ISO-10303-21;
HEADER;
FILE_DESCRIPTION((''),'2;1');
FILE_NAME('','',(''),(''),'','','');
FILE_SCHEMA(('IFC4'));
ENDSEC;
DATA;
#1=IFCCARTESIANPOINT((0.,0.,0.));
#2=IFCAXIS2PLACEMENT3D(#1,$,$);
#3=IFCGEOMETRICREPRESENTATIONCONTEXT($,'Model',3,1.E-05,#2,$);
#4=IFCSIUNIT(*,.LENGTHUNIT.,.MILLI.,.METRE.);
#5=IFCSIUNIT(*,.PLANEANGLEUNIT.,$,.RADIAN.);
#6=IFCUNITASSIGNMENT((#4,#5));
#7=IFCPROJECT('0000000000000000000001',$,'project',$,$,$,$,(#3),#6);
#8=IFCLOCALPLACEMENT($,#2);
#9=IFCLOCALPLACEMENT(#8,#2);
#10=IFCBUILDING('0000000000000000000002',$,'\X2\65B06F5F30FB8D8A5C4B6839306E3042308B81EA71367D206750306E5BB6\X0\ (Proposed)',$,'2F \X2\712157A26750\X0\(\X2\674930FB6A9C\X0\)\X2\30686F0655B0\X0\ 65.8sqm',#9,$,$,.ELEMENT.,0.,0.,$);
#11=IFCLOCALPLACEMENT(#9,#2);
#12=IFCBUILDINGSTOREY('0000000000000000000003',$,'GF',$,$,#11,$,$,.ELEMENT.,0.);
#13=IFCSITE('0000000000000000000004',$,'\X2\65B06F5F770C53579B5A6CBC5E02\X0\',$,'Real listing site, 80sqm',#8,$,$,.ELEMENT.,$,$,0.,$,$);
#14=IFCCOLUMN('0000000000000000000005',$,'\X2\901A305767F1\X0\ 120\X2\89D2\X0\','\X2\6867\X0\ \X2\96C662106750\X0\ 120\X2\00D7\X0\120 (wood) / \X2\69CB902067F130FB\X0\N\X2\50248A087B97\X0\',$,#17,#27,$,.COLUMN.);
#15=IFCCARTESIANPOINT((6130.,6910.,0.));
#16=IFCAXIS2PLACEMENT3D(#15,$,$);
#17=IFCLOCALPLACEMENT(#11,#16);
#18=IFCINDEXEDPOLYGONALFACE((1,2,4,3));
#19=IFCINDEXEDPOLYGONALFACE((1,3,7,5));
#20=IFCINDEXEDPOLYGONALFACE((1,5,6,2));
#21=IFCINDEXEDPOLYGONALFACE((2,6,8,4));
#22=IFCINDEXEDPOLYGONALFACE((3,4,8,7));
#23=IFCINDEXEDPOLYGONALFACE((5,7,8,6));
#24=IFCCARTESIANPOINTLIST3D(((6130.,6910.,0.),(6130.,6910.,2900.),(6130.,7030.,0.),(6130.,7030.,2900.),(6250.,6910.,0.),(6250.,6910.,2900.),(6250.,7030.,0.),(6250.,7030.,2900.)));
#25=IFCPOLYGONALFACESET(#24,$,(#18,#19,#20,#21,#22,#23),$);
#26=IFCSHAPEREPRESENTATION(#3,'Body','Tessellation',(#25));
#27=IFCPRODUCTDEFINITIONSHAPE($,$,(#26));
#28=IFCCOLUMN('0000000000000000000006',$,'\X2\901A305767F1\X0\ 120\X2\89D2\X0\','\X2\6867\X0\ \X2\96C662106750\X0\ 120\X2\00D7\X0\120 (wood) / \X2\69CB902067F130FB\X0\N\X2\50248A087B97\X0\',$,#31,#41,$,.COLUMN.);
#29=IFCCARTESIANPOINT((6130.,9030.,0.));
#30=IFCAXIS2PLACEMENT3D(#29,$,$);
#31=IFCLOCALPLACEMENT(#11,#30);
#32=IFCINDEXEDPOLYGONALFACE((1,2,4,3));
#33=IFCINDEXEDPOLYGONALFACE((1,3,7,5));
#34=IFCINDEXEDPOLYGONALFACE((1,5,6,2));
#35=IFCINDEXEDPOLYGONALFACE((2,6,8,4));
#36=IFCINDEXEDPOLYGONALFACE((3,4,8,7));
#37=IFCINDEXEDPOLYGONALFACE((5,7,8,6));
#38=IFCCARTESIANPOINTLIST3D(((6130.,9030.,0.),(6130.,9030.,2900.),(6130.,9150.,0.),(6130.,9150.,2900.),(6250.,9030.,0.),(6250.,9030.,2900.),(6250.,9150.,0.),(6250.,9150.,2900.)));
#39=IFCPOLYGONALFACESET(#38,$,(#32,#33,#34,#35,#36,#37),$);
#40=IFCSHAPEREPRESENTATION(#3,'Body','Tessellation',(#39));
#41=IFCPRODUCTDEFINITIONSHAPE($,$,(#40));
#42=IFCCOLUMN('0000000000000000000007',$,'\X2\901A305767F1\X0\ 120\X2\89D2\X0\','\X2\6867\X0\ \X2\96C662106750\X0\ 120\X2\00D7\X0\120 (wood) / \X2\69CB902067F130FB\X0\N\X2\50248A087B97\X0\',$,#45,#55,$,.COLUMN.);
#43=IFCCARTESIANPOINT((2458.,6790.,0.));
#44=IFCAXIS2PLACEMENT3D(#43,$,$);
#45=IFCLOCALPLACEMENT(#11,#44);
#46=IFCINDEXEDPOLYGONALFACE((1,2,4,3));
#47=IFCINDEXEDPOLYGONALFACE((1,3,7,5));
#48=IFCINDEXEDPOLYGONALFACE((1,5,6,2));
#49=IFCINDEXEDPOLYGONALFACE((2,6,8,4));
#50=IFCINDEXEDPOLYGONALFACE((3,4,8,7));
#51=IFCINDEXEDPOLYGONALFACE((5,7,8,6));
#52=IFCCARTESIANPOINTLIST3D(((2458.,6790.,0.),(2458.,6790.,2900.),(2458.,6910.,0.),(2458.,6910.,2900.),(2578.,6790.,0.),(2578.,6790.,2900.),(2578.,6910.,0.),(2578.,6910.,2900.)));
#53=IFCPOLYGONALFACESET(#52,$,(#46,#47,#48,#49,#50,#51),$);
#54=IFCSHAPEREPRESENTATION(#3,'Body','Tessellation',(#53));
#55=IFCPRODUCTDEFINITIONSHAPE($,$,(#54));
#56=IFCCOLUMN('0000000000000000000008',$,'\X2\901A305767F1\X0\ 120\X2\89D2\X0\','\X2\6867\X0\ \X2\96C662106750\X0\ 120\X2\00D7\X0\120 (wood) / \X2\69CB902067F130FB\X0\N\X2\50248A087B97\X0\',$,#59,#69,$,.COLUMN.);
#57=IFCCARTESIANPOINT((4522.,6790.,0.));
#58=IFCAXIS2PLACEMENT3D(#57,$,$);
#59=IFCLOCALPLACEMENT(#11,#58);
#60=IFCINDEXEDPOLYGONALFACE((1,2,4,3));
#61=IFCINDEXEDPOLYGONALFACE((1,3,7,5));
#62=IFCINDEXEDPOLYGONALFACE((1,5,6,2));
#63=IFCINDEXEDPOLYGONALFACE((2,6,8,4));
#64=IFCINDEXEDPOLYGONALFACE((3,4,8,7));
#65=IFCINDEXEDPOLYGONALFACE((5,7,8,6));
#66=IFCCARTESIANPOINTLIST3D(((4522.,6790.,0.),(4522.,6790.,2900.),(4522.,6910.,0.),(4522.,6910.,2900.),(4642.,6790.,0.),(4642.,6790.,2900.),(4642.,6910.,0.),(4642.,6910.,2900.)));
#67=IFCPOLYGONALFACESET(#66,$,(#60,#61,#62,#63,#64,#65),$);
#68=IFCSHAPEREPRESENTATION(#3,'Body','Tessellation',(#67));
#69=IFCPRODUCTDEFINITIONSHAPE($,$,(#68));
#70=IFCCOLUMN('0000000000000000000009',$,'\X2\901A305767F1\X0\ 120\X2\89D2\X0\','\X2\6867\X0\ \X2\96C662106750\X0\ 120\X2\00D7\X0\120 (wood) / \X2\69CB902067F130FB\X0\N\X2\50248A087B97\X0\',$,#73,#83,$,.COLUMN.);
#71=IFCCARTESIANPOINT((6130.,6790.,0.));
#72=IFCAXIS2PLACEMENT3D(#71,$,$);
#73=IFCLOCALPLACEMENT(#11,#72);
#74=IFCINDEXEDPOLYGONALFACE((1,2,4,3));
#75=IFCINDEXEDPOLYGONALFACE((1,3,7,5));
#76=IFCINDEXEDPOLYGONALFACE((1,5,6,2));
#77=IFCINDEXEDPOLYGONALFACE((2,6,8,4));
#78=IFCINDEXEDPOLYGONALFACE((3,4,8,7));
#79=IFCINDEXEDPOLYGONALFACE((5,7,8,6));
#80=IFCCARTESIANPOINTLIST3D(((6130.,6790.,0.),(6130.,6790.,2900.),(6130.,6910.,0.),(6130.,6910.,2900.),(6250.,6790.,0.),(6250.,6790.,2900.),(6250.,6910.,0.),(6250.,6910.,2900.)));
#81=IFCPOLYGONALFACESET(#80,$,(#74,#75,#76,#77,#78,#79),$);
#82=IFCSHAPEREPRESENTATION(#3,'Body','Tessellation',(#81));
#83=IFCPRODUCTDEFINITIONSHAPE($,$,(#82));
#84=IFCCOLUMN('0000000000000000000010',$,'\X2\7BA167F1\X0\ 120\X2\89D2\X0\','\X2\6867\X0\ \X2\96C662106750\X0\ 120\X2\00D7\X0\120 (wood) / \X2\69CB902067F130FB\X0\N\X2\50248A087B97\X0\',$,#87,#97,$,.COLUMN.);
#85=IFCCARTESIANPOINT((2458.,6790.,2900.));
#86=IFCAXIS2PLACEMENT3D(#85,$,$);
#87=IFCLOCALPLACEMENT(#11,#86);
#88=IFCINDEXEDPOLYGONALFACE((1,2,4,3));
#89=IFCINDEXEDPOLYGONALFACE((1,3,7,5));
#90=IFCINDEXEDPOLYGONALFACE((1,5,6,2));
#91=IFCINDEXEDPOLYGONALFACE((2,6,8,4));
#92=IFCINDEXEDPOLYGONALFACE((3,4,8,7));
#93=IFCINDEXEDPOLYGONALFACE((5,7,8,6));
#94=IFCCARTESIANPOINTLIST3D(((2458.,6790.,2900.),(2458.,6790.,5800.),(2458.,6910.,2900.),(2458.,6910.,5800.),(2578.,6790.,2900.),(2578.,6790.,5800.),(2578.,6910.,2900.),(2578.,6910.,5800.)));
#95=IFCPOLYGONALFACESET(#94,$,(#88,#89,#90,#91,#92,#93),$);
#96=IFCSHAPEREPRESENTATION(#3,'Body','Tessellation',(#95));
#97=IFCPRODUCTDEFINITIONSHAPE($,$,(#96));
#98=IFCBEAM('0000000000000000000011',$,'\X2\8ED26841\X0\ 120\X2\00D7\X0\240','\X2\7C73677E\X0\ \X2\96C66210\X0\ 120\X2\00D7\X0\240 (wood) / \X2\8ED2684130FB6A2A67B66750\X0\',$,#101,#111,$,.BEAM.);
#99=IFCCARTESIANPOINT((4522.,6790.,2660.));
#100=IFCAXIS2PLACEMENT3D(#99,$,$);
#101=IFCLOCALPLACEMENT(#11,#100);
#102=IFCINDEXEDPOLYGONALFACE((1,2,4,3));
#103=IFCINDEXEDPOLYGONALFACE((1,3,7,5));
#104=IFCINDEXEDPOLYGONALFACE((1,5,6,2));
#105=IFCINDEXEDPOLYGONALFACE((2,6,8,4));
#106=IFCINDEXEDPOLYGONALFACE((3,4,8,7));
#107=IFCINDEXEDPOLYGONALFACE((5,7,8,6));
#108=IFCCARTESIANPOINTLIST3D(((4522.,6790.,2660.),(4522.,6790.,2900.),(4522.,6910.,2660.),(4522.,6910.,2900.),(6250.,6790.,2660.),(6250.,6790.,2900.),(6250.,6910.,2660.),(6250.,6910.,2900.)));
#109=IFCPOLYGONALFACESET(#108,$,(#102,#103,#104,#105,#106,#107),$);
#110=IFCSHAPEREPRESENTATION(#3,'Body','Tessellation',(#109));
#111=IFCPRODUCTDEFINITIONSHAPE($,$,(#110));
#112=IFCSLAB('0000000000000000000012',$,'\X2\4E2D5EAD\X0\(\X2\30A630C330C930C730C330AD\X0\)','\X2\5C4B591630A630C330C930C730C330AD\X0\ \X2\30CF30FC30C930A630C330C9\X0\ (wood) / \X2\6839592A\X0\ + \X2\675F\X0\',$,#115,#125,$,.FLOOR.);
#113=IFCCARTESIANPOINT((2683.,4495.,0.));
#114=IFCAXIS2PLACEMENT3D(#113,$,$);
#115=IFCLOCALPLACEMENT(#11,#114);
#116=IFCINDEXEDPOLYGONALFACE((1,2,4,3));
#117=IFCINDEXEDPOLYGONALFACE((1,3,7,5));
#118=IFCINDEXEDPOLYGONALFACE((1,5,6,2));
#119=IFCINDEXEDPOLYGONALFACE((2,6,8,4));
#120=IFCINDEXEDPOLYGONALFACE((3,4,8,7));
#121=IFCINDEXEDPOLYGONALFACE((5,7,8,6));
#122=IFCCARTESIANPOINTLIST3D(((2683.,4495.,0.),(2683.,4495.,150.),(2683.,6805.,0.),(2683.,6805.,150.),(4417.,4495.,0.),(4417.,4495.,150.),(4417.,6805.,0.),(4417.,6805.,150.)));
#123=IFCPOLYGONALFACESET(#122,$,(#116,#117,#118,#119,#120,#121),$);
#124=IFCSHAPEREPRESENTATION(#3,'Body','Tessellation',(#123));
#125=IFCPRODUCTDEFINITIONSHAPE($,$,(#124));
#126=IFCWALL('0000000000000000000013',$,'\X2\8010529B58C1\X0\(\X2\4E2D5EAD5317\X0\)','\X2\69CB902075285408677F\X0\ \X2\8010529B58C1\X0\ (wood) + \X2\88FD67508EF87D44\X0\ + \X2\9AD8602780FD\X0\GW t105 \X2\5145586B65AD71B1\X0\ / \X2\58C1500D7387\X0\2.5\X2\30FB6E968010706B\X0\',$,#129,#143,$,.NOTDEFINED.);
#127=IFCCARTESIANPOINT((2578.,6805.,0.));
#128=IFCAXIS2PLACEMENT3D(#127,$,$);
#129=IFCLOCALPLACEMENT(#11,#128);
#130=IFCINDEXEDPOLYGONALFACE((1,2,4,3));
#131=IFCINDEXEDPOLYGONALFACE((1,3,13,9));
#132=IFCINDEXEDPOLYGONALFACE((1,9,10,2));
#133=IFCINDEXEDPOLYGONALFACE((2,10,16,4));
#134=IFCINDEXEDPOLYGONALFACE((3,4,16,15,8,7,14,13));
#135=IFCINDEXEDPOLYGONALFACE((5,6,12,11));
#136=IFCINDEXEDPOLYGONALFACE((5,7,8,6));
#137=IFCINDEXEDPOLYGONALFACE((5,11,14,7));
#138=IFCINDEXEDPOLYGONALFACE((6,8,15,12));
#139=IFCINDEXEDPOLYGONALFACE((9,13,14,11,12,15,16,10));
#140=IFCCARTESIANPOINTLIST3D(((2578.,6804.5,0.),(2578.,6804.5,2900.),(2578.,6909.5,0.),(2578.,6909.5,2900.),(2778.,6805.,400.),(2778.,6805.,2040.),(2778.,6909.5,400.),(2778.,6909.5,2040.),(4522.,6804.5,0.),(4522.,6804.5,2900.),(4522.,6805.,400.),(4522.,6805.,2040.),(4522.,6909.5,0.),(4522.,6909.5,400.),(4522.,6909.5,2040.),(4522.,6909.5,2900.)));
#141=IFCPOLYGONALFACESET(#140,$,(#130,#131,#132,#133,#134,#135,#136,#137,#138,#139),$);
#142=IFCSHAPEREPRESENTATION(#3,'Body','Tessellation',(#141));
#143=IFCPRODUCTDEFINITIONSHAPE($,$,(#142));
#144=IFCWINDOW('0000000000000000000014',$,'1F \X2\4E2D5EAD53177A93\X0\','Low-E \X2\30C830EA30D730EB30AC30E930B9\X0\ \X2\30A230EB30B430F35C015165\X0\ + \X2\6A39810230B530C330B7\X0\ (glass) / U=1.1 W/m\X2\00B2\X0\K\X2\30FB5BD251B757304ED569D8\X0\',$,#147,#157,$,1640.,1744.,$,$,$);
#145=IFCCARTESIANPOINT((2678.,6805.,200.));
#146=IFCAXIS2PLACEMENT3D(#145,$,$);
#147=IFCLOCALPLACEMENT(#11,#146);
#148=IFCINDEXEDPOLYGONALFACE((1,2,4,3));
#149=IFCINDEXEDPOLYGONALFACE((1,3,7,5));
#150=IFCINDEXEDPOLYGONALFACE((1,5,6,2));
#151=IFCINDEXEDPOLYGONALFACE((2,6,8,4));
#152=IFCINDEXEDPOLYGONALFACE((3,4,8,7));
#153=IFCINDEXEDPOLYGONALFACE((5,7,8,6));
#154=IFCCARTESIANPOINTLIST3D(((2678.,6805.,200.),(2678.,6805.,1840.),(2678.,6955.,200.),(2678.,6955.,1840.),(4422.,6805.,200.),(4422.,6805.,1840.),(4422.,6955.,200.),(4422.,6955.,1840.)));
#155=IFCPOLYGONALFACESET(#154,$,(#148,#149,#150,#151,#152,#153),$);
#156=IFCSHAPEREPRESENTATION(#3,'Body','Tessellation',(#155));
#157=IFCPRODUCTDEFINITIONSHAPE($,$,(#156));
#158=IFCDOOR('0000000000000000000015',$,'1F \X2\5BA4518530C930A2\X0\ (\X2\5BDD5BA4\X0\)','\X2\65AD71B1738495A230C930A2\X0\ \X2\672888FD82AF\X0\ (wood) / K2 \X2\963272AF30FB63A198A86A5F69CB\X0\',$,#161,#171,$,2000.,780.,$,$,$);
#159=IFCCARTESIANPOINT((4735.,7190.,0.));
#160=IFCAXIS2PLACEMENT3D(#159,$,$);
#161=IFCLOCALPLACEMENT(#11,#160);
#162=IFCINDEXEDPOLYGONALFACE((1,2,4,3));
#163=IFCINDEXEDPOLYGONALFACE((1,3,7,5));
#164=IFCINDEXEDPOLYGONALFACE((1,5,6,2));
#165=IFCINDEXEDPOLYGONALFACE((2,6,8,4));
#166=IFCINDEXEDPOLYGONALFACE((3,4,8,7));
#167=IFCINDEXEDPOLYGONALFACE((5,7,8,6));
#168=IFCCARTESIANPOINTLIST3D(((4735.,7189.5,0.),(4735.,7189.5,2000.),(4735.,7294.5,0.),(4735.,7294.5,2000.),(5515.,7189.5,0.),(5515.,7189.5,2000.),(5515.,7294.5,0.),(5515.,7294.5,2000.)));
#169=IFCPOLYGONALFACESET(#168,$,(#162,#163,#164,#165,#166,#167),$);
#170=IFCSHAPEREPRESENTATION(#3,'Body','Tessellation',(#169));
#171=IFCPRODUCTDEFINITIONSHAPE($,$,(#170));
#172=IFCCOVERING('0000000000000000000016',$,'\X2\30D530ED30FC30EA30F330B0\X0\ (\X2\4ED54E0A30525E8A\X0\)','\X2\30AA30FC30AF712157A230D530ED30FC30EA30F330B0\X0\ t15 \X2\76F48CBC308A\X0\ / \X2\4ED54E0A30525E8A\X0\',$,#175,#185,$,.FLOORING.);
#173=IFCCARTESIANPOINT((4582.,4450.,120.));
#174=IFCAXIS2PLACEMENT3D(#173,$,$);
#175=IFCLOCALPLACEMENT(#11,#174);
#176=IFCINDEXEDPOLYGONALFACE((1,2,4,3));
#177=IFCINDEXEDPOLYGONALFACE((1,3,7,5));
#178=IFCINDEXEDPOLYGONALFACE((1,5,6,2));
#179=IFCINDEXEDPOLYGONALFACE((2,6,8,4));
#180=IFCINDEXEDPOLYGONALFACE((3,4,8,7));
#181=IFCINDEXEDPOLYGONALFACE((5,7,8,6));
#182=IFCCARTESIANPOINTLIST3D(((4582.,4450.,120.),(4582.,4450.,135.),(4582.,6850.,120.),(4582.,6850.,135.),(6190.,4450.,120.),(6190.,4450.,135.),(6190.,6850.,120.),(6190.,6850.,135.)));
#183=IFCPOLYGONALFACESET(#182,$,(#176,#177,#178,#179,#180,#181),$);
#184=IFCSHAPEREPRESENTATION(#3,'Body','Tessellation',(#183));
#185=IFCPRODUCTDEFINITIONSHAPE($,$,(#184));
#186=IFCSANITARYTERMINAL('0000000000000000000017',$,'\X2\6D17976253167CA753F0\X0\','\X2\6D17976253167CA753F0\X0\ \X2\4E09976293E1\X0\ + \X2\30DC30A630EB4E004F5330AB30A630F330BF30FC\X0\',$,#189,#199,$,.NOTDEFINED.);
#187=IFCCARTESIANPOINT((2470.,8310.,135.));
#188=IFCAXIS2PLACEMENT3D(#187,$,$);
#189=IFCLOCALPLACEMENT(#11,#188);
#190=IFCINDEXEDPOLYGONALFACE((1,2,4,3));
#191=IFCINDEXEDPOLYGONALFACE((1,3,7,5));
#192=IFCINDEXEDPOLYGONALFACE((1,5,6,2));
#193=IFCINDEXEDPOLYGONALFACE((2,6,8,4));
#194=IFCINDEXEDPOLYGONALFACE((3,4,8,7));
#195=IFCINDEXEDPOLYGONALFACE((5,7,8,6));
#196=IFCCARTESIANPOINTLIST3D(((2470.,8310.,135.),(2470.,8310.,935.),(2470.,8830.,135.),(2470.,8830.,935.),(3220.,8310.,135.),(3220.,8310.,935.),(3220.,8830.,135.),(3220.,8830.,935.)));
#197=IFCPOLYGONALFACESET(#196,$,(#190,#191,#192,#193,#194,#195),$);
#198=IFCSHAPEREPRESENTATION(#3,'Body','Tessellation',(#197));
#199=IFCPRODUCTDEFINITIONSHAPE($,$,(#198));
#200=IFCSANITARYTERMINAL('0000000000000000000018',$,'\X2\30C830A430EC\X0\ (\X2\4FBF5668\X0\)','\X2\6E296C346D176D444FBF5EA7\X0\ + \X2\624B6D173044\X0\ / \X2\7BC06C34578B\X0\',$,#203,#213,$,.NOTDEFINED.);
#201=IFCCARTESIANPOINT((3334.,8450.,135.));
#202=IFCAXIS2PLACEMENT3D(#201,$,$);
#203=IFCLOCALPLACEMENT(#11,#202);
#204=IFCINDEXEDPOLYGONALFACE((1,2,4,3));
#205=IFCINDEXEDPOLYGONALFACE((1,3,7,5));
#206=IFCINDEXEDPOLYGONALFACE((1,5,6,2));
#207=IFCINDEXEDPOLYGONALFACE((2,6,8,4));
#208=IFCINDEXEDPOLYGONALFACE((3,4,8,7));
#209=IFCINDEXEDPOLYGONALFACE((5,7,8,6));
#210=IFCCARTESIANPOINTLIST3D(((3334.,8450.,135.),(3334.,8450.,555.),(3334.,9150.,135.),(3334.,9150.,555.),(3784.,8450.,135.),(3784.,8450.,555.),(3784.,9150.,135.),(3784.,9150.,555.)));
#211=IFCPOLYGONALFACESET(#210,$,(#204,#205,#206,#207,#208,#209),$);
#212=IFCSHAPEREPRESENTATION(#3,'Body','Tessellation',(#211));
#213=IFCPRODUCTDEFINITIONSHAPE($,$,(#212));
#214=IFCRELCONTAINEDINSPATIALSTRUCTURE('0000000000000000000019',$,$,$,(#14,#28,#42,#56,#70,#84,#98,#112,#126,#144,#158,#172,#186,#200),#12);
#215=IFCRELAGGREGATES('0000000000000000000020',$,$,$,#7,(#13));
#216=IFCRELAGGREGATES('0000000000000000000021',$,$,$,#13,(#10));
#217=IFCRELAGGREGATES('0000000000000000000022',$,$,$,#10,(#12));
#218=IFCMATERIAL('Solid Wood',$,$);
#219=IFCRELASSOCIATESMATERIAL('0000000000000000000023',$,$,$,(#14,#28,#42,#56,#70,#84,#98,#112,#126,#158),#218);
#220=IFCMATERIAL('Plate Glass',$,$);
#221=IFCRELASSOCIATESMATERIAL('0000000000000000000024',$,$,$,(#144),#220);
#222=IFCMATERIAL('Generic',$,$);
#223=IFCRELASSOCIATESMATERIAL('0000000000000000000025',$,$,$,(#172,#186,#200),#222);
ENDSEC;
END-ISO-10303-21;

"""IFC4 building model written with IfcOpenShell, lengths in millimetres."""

from ifc_helpers import new_model, si_unit, frame, frame_2d, origin, place, context, project, spatial, rectangle, extrude, material, element, fill, save


model = new_model("IFC4")

# Units and contexts
model_context = context("Model", 3, precision=1e-05, world=origin())
ifc_project = project(units=[si_unit("LENGTHUNIT", "METRE", prefix="MILLI"), si_unit("PLANEANGLEUNIT", "RADIAN")], contexts=[model_context])

# Site, building, storey
site_placement = place(None, origin())
site = spatial("IfcSite", under=ifc_project, at=site_placement, Name="新潟県南魚沼市", ObjectType="Real listing site, 80sqm", CompositionType="ELEMENT", RefElevation=0.0)
building_placement = place(site_placement, origin())
building = spatial("IfcBuilding", under=site, at=building_placement, Name="新潟・越屋根のある自然素材の家 (Proposed)", ObjectType="2F 無垢材(杉・檜)と漆喰 65.8sqm", CompositionType="ELEMENT", ElevationOfRefHeight=0.0, ElevationOfTerrain=0.0)
storey_placement = place(building_placement, origin())
storey = spatial("IfcBuildingStorey", under=building, at=storey_placement, Name="GF", CompositionType="ELEMENT", Elevation=0.0)

# Columns
ifc_material_1 = material(Name="Solid Wood")
column_1_placement = place(storey_placement, frame((6130.0, 6910.0, 0.0)))
element("IfcColumn", 1, at=column_1_placement, inside=storey, material=ifc_material_1, Name="通し柱 120角", Description="桧 集成材 120×120 (wood) / 構造柱・N値計算", PredefinedType="COLUMN", context=model_context, shape_type="SweptSolid", body=[
    extrude(rectangle(XDim=120.0, YDim=120.0, at=frame_2d((60.0, 60.0))), frame((6130.0, 6910.0, 0.0)), (0.0, 0.0, 1.0), 2900.0),
])
column_2_placement = place(storey_placement, frame((6130.0, 9030.0, 0.0)))
element("IfcColumn", 2, at=column_2_placement, inside=storey, material=ifc_material_1, Name="通し柱 120角", Description="桧 集成材 120×120 (wood) / 構造柱・N値計算", PredefinedType="COLUMN", context=model_context, shape_type="SweptSolid", body=[
    extrude(rectangle(XDim=120.0, YDim=120.0, at=frame_2d((60.0, 60.0))), frame((6130.0, 9030.0, 0.0)), (0.0, 0.0, 1.0), 2900.0),
])
column_3_placement = place(storey_placement, frame((2458.0, 6790.0, 0.0)))
element("IfcColumn", 3, at=column_3_placement, inside=storey, material=ifc_material_1, Name="通し柱 120角", Description="桧 集成材 120×120 (wood) / 構造柱・N値計算", PredefinedType="COLUMN", context=model_context, shape_type="SweptSolid", body=[
    extrude(rectangle(XDim=120.0, YDim=120.0, at=frame_2d((60.0, 60.0))), frame((2458.0, 6790.0, 0.0)), (0.0, 0.0, 1.0), 2900.0),
])
column_4_placement = place(storey_placement, frame((4522.0, 6790.0, 0.0)))
element("IfcColumn", 4, at=column_4_placement, inside=storey, material=ifc_material_1, Name="通し柱 120角", Description="桧 集成材 120×120 (wood) / 構造柱・N値計算", PredefinedType="COLUMN", context=model_context, shape_type="SweptSolid", body=[
    extrude(rectangle(XDim=120.0, YDim=120.0, at=frame_2d((60.0, 60.0))), frame((4522.0, 6790.0, 0.0)), (0.0, 0.0, 1.0), 2900.0),
])
column_5_placement = place(storey_placement, frame((6130.0, 6790.0, 0.0)))
element("IfcColumn", 5, at=column_5_placement, inside=storey, material=ifc_material_1, Name="通し柱 120角", Description="桧 集成材 120×120 (wood) / 構造柱・N値計算", PredefinedType="COLUMN", context=model_context, shape_type="SweptSolid", body=[
    extrude(rectangle(XDim=120.0, YDim=120.0, at=frame_2d((60.0, 60.0))), frame((6130.0, 6790.0, 0.0)), (0.0, 0.0, 1.0), 2900.0),
])
column_6_placement = place(storey_placement, frame((2458.0, 6790.0, 2900.0)))
element("IfcColumn", 6, at=column_6_placement, inside=storey, material=ifc_material_1, Name="管柱 120角", Description="桧 集成材 120×120 (wood) / 構造柱・N値計算", PredefinedType="COLUMN", context=model_context, shape_type="SweptSolid", body=[
    extrude(rectangle(XDim=120.0, YDim=120.0, at=frame_2d((60.0, 60.0))), frame((2458.0, 6790.0, 2900.0)), (0.0, 0.0, 1.0), 2900.0),
])

# Beam
beam_1_placement = place(storey_placement, frame((4522.0, 6790.0, 2660.0)))
element("IfcBeam", 7, at=beam_1_placement, inside=storey, material=ifc_material_1, Name="軒桁 120×240", Description="米松 集成 120×240 (wood) / 軒桁・横架材", PredefinedType="BEAM", context=model_context, shape_type="SweptSolid", body=[
    extrude(rectangle(XDim=1728.0, YDim=120.0, at=frame_2d((864.0, 60.0))), frame((4522.0, 6790.0, 2660.0)), (0.0, 0.0, 1.0), 240.0),
])

# Slab
slab_placement = place(storey_placement, frame((2683.0, 4495.0, 0.0)))
element("IfcSlab", 8, at=slab_placement, inside=storey, material=ifc_material_1, Name="中庭(ウッドデッキ)", Description="屋外ウッドデッキ ハードウッド (wood) / 根太 + 束", PredefinedType="FLOOR", context=model_context, shape_type="SweptSolid", body=[
    extrude(rectangle(XDim=1734.0, YDim=2310.0, at=frame_2d((867.0, 1155.0))), frame((2683.0, 4495.0, 0.0)), (0.0, 0.0, 1.0), 150.0),
])

# Wall, opening, window
wall_1_placement = place(storey_placement, frame((2578.0, 6805.0, 0.0)))
wall_1 = element("IfcWall", 9, at=wall_1_placement, inside=storey, material=ifc_material_1, Name="耐力壁(中庭北)", Description="構造用合板 耐力壁 (wood) + 製材軸組 + 高性能GW t105 充填断熱 / 壁倍率2.5・準耐火", PredefinedType="NOTDEFINED", context=model_context, shape_type="SweptSolid", body=[
    extrude(rectangle(XDim=1944.0, YDim=105.0, at=frame_2d((972.0, 52.0))), frame((2578.0, 6805.0, 0.0)), (0.0, 0.0, 1.0), 2900.0),
])
opening_placement = place(storey_placement, frame((2678.0, 6805.0, 200.0)))
opening = element("IfcOpeningElement", 10, at=opening_placement, cuts=wall_1, PredefinedType="NOTDEFINED", context=model_context, shape_type="SweptSolid", body=[
    extrude(rectangle(XDim=1744.0, YDim=150.0, at=frame_2d((872.0, 75.0))), frame((2678.0, 6805.0, 200.0)), (0.0, 0.0, 1.0), 1640.0),
])
ifc_material_2 = material(Name="Plate Glass")
window_placement = place(storey_placement, frame((2678.0, 6805.0, 200.0)))
window = element("IfcWindow", 11, at=window_placement, inside=storey, material=ifc_material_2, Name="1F 中庭北窓", Description="Low-E トリプルガラス アルゴン封入 + 樹脂サッシ (glass) / U=1.1 W/m²K・寒冷地仕様", OverallHeight=1640.0, OverallWidth=1744.0, context=model_context, shape_type="SweptSolid", body=[
    extrude(rectangle(XDim=1744.0, YDim=150.0, at=frame_2d((872.0, 75.0))), frame((2678.0, 6805.0, 200.0)), (0.0, 0.0, 1.0), 1640.0),
])
fill(opening, window)

# Door
door_placement = place(storey_placement, frame((4735.0, 7190.0, 0.0)))
element("IfcDoor", 12, at=door_placement, inside=storey, material=ifc_material_1, Name="1F 室内ドア (寝室)", Description="断熱玄関ドア 木製芯 (wood) / K2 防犯・採風機構", OverallHeight=2000.0, OverallWidth=780.0, context=model_context, shape_type="SweptSolid", body=[
    extrude(rectangle(XDim=780.0, YDim=105.0, at=frame_2d((390.0, 52.0))), frame((4735.0, 7190.0, 0.0)), (0.0, 0.0, 1.0), 2000.0),
])

# Covering
ifc_material_3 = material(Name="Generic")
covering_placement = place(storey_placement, frame((4582.0, 4450.0, 120.0)))
element("IfcCovering", 13, at=covering_placement, inside=storey, material=ifc_material_3, Name="フローリング (仕上げ床)", Description="オーク無垢フローリング t15 直貼り / 仕上げ床", PredefinedType="FLOORING", context=model_context, shape_type="SweptSolid", body=[
    extrude(rectangle(XDim=1608.0, YDim=2400.0, at=frame_2d((804.0, 1200.0))), frame((4582.0, 4450.0, 120.0)), (0.0, 0.0, 1.0), 15.0),
])

# Sanitary terminals
sanitary_terminal_1_placement = place(storey_placement, frame((2470.0, 8310.0, 135.0)))
element("IfcSanitaryTerminal", 14, at=sanitary_terminal_1_placement, inside=storey, material=ifc_material_3, Name="洗面化粧台", Description="洗面化粧台 三面鏡 + ボウル一体カウンター", PredefinedType="NOTDEFINED", context=model_context, shape_type="SweptSolid", body=[
    extrude(rectangle(XDim=750.0, YDim=520.0, at=frame_2d((375.0, 260.0))), frame((2470.0, 8310.0, 135.0)), (0.0, 0.0, 1.0), 800.0),
])
sanitary_terminal_2_placement = place(storey_placement, frame((3334.0, 8450.0, 135.0)))
element("IfcSanitaryTerminal", 15, at=sanitary_terminal_2_placement, inside=storey, material=ifc_material_3, Name="トイレ (便器)", Description="温水洗浄便座 + 手洗い / 節水型", PredefinedType="NOTDEFINED", context=model_context, shape_type="SweptSolid", body=[
    extrude(rectangle(XDim=450.0, YDim=700.0, at=frame_2d((225.0, 350.0))), frame((3334.0, 8450.0, 135.0)), (0.0, 0.0, 1.0), 420.0),
])

save(model, "model.ifc")
